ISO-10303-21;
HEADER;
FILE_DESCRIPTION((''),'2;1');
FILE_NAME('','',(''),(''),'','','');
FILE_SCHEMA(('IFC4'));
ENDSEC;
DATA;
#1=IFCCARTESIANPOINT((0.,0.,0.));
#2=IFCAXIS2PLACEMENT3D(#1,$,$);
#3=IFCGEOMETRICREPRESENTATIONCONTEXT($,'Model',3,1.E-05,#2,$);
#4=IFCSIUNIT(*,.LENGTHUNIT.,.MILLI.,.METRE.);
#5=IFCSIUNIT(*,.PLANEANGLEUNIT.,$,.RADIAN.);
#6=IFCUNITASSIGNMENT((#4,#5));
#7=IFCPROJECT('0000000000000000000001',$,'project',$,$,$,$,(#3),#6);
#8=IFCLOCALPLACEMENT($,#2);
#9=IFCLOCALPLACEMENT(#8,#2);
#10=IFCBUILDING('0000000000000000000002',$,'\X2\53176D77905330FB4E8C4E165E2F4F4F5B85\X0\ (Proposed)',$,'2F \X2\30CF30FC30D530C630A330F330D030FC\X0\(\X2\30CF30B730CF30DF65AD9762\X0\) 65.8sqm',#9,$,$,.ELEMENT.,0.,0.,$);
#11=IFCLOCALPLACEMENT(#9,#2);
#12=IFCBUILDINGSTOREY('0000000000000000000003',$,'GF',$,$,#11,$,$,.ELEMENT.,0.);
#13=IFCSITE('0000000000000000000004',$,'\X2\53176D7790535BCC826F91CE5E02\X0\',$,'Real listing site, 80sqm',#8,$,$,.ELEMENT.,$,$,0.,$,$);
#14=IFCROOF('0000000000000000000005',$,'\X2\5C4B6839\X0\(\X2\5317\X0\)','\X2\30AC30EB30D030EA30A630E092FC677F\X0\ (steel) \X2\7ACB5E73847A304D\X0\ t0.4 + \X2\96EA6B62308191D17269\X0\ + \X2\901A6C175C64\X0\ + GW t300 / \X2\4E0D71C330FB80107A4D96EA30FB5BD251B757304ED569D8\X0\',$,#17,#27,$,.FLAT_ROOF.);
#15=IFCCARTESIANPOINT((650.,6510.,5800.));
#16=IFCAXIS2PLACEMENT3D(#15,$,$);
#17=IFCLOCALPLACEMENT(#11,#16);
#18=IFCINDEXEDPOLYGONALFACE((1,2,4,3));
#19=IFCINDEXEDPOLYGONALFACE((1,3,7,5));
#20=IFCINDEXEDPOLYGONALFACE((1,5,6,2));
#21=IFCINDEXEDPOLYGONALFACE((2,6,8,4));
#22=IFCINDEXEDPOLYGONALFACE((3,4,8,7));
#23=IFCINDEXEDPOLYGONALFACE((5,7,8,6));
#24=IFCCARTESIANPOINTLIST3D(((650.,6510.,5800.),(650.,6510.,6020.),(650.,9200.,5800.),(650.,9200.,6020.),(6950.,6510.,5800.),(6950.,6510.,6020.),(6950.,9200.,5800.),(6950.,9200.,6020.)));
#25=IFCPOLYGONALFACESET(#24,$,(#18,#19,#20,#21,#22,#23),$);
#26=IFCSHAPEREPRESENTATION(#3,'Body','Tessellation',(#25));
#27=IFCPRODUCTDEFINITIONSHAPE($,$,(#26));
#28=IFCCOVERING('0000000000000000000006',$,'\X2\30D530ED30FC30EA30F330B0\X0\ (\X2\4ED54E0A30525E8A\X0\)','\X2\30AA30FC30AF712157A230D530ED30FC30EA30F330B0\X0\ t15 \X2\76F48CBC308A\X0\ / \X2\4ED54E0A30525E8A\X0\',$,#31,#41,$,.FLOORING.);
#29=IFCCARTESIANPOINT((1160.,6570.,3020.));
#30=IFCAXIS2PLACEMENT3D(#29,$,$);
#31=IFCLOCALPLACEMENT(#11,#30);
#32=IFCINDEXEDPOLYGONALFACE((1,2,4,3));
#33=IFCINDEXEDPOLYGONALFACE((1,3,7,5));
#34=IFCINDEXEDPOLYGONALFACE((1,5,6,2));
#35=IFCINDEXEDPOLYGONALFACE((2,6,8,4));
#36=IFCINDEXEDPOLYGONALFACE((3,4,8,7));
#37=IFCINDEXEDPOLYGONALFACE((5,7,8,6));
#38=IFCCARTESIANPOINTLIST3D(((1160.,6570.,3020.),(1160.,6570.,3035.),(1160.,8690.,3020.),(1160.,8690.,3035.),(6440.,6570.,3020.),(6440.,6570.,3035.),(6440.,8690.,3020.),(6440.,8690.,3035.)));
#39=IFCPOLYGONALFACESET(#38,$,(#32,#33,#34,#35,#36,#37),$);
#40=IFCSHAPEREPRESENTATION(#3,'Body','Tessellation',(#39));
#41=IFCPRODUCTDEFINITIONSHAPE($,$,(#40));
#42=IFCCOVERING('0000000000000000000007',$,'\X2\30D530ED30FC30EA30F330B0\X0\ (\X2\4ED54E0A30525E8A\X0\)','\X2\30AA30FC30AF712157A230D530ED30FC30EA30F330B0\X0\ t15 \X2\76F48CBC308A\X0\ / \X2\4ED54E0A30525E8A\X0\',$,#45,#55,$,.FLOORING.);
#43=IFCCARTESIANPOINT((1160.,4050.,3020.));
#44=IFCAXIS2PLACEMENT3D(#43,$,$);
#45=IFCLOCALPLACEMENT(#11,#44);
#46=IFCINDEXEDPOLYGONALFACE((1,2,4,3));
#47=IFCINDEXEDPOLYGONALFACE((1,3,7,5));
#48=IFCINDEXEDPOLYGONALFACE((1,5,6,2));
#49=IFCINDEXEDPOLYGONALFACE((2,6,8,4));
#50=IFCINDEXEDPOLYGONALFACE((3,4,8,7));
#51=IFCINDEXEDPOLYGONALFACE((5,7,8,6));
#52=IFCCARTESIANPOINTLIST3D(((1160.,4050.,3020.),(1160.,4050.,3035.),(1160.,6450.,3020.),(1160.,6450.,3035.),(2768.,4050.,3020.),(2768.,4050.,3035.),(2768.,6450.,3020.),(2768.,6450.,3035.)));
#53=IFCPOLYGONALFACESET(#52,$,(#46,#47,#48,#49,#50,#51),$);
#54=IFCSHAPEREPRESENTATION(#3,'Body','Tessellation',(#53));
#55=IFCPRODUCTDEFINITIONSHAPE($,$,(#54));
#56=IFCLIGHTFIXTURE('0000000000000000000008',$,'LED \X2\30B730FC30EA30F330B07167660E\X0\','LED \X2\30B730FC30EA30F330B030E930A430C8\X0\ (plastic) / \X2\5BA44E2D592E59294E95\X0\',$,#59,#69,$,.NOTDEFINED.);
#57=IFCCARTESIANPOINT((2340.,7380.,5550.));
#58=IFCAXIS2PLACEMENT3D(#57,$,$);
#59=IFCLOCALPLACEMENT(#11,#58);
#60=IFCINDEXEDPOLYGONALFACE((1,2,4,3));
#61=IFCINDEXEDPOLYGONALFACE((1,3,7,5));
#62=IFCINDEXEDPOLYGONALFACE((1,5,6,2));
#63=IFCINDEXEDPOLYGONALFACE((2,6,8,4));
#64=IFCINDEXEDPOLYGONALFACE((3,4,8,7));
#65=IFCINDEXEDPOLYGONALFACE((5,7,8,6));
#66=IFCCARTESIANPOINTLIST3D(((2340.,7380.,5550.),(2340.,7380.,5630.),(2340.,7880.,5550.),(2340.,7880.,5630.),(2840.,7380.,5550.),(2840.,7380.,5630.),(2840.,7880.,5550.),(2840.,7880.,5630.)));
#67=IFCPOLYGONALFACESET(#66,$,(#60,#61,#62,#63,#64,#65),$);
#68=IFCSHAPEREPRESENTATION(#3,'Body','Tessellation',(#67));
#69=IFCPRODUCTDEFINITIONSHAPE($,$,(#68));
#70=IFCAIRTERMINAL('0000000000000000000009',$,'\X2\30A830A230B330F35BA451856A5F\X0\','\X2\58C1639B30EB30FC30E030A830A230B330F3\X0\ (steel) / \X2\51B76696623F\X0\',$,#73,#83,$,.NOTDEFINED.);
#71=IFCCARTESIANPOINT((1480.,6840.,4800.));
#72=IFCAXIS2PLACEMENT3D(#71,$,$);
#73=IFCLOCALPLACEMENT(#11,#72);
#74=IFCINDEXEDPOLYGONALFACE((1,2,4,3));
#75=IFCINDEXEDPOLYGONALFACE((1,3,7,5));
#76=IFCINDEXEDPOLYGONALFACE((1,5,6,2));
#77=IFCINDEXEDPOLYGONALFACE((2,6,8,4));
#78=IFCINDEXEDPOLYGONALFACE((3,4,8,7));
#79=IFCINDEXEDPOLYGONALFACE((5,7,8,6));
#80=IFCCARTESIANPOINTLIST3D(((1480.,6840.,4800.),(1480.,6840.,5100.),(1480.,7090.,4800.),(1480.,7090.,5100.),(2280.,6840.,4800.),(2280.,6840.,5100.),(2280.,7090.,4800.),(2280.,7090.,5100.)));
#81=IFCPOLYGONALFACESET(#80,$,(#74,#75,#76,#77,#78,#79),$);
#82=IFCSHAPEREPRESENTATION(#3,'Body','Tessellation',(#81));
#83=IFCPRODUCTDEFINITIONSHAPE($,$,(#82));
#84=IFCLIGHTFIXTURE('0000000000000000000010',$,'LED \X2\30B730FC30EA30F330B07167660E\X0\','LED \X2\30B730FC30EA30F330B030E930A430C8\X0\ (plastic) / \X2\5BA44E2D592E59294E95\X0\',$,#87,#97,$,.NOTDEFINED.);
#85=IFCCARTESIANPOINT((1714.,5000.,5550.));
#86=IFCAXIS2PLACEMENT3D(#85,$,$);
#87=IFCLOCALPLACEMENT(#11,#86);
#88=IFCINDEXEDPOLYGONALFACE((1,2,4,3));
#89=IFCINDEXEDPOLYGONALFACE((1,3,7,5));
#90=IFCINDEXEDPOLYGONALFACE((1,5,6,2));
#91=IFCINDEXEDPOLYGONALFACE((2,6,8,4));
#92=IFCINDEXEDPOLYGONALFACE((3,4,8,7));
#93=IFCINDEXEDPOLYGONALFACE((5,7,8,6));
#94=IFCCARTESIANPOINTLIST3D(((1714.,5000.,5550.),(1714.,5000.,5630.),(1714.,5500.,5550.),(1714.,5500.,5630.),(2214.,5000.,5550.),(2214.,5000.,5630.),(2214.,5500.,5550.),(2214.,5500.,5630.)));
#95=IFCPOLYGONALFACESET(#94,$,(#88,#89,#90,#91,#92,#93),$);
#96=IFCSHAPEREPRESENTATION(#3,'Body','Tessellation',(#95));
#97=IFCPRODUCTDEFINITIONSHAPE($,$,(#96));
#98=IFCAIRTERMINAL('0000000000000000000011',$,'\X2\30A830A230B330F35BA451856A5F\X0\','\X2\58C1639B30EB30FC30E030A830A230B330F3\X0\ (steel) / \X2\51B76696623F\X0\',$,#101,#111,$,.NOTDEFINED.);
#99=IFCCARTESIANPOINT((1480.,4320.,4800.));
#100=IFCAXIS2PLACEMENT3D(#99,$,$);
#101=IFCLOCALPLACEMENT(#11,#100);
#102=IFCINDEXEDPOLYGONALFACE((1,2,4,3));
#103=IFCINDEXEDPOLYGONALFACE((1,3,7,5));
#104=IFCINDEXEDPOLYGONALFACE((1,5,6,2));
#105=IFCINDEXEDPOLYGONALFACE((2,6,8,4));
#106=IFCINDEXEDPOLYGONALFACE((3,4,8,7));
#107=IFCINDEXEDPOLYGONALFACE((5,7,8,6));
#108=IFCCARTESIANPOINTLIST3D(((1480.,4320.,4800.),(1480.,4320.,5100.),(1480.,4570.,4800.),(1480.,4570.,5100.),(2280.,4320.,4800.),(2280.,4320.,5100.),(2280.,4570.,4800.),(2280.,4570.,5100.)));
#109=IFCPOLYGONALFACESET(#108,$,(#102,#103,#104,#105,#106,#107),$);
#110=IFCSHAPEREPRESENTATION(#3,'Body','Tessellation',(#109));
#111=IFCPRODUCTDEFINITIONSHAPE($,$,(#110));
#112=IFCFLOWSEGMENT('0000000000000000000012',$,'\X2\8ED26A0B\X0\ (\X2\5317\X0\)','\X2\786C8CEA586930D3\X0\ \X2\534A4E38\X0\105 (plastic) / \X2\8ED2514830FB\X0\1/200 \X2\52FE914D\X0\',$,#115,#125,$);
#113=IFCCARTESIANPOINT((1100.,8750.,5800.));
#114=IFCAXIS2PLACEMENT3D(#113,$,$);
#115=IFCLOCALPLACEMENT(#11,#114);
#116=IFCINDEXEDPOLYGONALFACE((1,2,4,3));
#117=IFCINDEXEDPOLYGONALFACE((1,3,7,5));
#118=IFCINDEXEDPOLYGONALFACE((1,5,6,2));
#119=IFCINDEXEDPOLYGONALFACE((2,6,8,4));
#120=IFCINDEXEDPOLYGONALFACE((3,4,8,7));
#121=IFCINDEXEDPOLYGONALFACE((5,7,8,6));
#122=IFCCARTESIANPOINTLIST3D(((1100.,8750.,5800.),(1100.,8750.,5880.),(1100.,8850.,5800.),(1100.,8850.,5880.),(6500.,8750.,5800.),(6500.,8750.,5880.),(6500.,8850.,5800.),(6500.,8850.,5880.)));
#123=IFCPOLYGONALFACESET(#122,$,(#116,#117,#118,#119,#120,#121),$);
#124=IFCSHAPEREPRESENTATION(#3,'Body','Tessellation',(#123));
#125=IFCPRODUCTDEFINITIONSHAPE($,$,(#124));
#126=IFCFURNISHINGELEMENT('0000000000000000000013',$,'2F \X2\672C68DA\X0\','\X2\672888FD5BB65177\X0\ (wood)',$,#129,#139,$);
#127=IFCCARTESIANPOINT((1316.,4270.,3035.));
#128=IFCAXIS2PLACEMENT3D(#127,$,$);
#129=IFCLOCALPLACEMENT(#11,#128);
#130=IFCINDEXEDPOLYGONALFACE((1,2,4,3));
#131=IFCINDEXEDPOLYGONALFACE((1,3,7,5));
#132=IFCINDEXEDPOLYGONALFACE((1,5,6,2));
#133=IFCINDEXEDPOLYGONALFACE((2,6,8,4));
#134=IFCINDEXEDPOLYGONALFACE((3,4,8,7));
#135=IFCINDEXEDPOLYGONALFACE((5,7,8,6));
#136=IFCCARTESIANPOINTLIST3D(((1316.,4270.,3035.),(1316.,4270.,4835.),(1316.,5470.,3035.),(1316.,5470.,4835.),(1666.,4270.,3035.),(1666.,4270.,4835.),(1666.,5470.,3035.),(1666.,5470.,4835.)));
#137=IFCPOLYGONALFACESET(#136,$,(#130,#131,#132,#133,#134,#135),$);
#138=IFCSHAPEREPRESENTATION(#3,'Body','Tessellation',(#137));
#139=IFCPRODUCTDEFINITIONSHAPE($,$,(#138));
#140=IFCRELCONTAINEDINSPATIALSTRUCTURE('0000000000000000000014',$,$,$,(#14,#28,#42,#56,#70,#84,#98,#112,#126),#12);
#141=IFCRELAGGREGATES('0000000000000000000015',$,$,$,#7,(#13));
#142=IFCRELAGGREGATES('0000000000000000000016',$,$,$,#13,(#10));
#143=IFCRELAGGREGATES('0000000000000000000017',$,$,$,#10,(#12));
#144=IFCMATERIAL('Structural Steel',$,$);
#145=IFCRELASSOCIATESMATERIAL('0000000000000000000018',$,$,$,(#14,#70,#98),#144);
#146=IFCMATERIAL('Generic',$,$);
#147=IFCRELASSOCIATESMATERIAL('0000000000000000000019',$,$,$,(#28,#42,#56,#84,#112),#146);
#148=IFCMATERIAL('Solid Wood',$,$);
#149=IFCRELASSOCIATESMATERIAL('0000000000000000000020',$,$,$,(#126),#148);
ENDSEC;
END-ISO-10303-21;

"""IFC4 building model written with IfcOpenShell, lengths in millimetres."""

from ifc_helpers import new_model, si_unit, frame, frame_2d, origin, place, context, project, spatial, rectangle, extrude, material, element, save


model = new_model("IFC4")

# Units and contexts
model_context = context("Model", 3, precision=1e-05, world=origin())
ifc_project = project(units=[si_unit("LENGTHUNIT", "METRE", prefix="MILLI"), si_unit("PLANEANGLEUNIT", "RADIAN")], contexts=[model_context])

# Site, building, storey
site_placement = place(None, origin())
site = spatial("IfcSite", under=ifc_project, at=site_placement, Name="北海道富良野市", ObjectType="Real listing site, 80sqm", CompositionType="ELEMENT", RefElevation=0.0)
building_placement = place(site_placement, origin())
building = spatial("IfcBuilding", under=site, at=building_placement, Name="北海道・二世帯住宅 (Proposed)", ObjectType="2F ハーフティンバー(ハシハミ断面) 65.8sqm", CompositionType="ELEMENT", ElevationOfRefHeight=0.0, ElevationOfTerrain=0.0)
storey_placement = place(building_placement, origin())
storey = spatial("IfcBuildingStorey", under=building, at=storey_placement, Name="GF", CompositionType="ELEMENT", Elevation=0.0)

# Shared definitions
ifc_material_1 = material(Name="Solid Wood")

# Roof
ifc_material_2 = material(Name="Structural Steel")
for number, where, name in (
    (1, (650.0, 6510.0, 5800.0), "屋根(北)"),
):
    element("IfcRoof", number, at=place(storey_placement, frame(where)), inside=storey, material=ifc_material_2, Name=name, Description="ガルバリウム鋼板 (steel) 立平葺き t0.4 + 雪止め金物 + 通気層 + GW t300 / 不燃・耐積雪・寒冷地仕様", PredefinedType="FLAT_ROOF", context=model_context, shape_type="SweptSolid", body=[
        extrude(rectangle(XDim=6300.0, YDim=2690.0, at=frame_2d((3150.0, 1345.0))), frame((650.0, 6510.0, 5800.0)), (0.0, 0.0, 1.0), 220.0),
    ])

# Coverings
ifc_material_3 = material(Name="Generic")
covering_1_placement = place(storey_placement, frame((1160.0, 6570.0, 3020.0)))
element("IfcCovering", 2, at=covering_1_placement, inside=storey, material=ifc_material_3, Name="フローリング (仕上げ床)", Description="オーク無垢フローリング t15 直貼り / 仕上げ床", PredefinedType="FLOORING", context=model_context, shape_type="SweptSolid", body=[
    extrude(rectangle(XDim=5280.0, YDim=2120.0, at=frame_2d((2640.0, 1060.0))), frame((1160.0, 6570.0, 3020.0)), (0.0, 0.0, 1.0), 15.0),
])
covering_2_placement = place(storey_placement, frame((1160.0, 4050.0, 3020.0)))
element("IfcCovering", 3, at=covering_2_placement, inside=storey, material=ifc_material_3, Name="フローリング (仕上げ床)", Description="オーク無垢フローリング t15 直貼り / 仕上げ床", PredefinedType="FLOORING", context=model_context, shape_type="SweptSolid", body=[
    extrude(rectangle(XDim=1608.0, YDim=2400.0, at=frame_2d((804.0, 1200.0))), frame((1160.0, 4050.0, 3020.0)), (0.0, 0.0, 1.0), 15.0),
])

# Light fixture
light_fixture_1_placement = place(storey_placement, frame((2340.0, 7380.0, 5550.0)))
element("IfcLightFixture", 4, at=light_fixture_1_placement, inside=storey, material=ifc_material_3, Name="LED シーリング照明", Description="LED シーリングライト (plastic) / 室中央天井", PredefinedType="NOTDEFINED", context=model_context, shape_type="SweptSolid", body=[
    extrude(rectangle(XDim=500.0, YDim=500.0, at=frame_2d((250.0, 250.0))), frame((2340.0, 7380.0, 5550.0)), (0.0, 0.0, 1.0), 80.0),
])

# Air terminal
air_terminal_1_placement = place(storey_placement, frame((1480.0, 6840.0, 4800.0)))
element("IfcAirTerminal", 5, at=air_terminal_1_placement, inside=storey, material=ifc_material_2, Name="エアコン室内機", Description="壁掛ルームエアコン (steel) / 冷暖房", PredefinedType="NOTDEFINED", context=model_context, shape_type="SweptSolid", body=[
    extrude(rectangle(XDim=800.0, YDim=250.0, at=frame_2d((400.0, 125.0))), frame((1480.0, 6840.0, 4800.0)), (0.0, 0.0, 1.0), 300.0),
])

# Light fixture
light_fixture_2_placement = place(storey_placement, frame((1714.0, 5000.0, 5550.0)))
element("IfcLightFixture", 6, at=light_fixture_2_placement, inside=storey, material=ifc_material_3, Name="LED シーリング照明", Description="LED シーリングライト (plastic) / 室中央天井", PredefinedType="NOTDEFINED", context=model_context, shape_type="SweptSolid", body=[
    extrude(rectangle(XDim=500.0, YDim=500.0, at=frame_2d((250.0, 250.0))), frame((1714.0, 5000.0, 5550.0)), (0.0, 0.0, 1.0), 80.0),
])

# Air terminal
air_terminal_2_placement = place(storey_placement, frame((1480.0, 4320.0, 4800.0)))
element("IfcAirTerminal", 7, at=air_terminal_2_placement, inside=storey, material=ifc_material_2, Name="エアコン室内機", Description="壁掛ルームエアコン (steel) / 冷暖房", PredefinedType="NOTDEFINED", context=model_context, shape_type="SweptSolid", body=[
    extrude(rectangle(XDim=800.0, YDim=250.0, at=frame_2d((400.0, 125.0))), frame((1480.0, 4320.0, 4800.0)), (0.0, 0.0, 1.0), 300.0),
])

# Flow segment
flow_segment_placement = place(storey_placement, frame((1100.0, 8750.0, 5800.0)))
element("IfcFlowSegment", 8, at=flow_segment_placement, inside=storey, material=ifc_material_3, Name="軒樋 (北)", Description="硬質塩ビ 半丸105 (plastic) / 軒先・1/200 勾配", context=model_context, shape_type="SweptSolid", body=[
    extrude(rectangle(XDim=5400.0, YDim=100.0, at=frame_2d((2700.0, 50.0))), frame((1100.0, 8750.0, 5800.0)), (0.0, 0.0, 1.0), 80.0),
])

# Furnishing element
furnishing_placement = place(storey_placement, frame((1316.0, 4270.0, 3035.0)))
element("IfcFurnishingElement", 9, at=furnishing_placement, inside=storey, material=ifc_material_1, Name="2F 本棚", Description="木製家具 (wood)", context=model_context, shape_type="SweptSolid", body=[
    extrude(rectangle(XDim=350.0, YDim=1200.0, at=frame_2d((175.0, 600.0))), frame((1316.0, 4270.0, 3035.0)), (0.0, 0.0, 1.0), 1800.0),
])

save(model, "model.ifc")
